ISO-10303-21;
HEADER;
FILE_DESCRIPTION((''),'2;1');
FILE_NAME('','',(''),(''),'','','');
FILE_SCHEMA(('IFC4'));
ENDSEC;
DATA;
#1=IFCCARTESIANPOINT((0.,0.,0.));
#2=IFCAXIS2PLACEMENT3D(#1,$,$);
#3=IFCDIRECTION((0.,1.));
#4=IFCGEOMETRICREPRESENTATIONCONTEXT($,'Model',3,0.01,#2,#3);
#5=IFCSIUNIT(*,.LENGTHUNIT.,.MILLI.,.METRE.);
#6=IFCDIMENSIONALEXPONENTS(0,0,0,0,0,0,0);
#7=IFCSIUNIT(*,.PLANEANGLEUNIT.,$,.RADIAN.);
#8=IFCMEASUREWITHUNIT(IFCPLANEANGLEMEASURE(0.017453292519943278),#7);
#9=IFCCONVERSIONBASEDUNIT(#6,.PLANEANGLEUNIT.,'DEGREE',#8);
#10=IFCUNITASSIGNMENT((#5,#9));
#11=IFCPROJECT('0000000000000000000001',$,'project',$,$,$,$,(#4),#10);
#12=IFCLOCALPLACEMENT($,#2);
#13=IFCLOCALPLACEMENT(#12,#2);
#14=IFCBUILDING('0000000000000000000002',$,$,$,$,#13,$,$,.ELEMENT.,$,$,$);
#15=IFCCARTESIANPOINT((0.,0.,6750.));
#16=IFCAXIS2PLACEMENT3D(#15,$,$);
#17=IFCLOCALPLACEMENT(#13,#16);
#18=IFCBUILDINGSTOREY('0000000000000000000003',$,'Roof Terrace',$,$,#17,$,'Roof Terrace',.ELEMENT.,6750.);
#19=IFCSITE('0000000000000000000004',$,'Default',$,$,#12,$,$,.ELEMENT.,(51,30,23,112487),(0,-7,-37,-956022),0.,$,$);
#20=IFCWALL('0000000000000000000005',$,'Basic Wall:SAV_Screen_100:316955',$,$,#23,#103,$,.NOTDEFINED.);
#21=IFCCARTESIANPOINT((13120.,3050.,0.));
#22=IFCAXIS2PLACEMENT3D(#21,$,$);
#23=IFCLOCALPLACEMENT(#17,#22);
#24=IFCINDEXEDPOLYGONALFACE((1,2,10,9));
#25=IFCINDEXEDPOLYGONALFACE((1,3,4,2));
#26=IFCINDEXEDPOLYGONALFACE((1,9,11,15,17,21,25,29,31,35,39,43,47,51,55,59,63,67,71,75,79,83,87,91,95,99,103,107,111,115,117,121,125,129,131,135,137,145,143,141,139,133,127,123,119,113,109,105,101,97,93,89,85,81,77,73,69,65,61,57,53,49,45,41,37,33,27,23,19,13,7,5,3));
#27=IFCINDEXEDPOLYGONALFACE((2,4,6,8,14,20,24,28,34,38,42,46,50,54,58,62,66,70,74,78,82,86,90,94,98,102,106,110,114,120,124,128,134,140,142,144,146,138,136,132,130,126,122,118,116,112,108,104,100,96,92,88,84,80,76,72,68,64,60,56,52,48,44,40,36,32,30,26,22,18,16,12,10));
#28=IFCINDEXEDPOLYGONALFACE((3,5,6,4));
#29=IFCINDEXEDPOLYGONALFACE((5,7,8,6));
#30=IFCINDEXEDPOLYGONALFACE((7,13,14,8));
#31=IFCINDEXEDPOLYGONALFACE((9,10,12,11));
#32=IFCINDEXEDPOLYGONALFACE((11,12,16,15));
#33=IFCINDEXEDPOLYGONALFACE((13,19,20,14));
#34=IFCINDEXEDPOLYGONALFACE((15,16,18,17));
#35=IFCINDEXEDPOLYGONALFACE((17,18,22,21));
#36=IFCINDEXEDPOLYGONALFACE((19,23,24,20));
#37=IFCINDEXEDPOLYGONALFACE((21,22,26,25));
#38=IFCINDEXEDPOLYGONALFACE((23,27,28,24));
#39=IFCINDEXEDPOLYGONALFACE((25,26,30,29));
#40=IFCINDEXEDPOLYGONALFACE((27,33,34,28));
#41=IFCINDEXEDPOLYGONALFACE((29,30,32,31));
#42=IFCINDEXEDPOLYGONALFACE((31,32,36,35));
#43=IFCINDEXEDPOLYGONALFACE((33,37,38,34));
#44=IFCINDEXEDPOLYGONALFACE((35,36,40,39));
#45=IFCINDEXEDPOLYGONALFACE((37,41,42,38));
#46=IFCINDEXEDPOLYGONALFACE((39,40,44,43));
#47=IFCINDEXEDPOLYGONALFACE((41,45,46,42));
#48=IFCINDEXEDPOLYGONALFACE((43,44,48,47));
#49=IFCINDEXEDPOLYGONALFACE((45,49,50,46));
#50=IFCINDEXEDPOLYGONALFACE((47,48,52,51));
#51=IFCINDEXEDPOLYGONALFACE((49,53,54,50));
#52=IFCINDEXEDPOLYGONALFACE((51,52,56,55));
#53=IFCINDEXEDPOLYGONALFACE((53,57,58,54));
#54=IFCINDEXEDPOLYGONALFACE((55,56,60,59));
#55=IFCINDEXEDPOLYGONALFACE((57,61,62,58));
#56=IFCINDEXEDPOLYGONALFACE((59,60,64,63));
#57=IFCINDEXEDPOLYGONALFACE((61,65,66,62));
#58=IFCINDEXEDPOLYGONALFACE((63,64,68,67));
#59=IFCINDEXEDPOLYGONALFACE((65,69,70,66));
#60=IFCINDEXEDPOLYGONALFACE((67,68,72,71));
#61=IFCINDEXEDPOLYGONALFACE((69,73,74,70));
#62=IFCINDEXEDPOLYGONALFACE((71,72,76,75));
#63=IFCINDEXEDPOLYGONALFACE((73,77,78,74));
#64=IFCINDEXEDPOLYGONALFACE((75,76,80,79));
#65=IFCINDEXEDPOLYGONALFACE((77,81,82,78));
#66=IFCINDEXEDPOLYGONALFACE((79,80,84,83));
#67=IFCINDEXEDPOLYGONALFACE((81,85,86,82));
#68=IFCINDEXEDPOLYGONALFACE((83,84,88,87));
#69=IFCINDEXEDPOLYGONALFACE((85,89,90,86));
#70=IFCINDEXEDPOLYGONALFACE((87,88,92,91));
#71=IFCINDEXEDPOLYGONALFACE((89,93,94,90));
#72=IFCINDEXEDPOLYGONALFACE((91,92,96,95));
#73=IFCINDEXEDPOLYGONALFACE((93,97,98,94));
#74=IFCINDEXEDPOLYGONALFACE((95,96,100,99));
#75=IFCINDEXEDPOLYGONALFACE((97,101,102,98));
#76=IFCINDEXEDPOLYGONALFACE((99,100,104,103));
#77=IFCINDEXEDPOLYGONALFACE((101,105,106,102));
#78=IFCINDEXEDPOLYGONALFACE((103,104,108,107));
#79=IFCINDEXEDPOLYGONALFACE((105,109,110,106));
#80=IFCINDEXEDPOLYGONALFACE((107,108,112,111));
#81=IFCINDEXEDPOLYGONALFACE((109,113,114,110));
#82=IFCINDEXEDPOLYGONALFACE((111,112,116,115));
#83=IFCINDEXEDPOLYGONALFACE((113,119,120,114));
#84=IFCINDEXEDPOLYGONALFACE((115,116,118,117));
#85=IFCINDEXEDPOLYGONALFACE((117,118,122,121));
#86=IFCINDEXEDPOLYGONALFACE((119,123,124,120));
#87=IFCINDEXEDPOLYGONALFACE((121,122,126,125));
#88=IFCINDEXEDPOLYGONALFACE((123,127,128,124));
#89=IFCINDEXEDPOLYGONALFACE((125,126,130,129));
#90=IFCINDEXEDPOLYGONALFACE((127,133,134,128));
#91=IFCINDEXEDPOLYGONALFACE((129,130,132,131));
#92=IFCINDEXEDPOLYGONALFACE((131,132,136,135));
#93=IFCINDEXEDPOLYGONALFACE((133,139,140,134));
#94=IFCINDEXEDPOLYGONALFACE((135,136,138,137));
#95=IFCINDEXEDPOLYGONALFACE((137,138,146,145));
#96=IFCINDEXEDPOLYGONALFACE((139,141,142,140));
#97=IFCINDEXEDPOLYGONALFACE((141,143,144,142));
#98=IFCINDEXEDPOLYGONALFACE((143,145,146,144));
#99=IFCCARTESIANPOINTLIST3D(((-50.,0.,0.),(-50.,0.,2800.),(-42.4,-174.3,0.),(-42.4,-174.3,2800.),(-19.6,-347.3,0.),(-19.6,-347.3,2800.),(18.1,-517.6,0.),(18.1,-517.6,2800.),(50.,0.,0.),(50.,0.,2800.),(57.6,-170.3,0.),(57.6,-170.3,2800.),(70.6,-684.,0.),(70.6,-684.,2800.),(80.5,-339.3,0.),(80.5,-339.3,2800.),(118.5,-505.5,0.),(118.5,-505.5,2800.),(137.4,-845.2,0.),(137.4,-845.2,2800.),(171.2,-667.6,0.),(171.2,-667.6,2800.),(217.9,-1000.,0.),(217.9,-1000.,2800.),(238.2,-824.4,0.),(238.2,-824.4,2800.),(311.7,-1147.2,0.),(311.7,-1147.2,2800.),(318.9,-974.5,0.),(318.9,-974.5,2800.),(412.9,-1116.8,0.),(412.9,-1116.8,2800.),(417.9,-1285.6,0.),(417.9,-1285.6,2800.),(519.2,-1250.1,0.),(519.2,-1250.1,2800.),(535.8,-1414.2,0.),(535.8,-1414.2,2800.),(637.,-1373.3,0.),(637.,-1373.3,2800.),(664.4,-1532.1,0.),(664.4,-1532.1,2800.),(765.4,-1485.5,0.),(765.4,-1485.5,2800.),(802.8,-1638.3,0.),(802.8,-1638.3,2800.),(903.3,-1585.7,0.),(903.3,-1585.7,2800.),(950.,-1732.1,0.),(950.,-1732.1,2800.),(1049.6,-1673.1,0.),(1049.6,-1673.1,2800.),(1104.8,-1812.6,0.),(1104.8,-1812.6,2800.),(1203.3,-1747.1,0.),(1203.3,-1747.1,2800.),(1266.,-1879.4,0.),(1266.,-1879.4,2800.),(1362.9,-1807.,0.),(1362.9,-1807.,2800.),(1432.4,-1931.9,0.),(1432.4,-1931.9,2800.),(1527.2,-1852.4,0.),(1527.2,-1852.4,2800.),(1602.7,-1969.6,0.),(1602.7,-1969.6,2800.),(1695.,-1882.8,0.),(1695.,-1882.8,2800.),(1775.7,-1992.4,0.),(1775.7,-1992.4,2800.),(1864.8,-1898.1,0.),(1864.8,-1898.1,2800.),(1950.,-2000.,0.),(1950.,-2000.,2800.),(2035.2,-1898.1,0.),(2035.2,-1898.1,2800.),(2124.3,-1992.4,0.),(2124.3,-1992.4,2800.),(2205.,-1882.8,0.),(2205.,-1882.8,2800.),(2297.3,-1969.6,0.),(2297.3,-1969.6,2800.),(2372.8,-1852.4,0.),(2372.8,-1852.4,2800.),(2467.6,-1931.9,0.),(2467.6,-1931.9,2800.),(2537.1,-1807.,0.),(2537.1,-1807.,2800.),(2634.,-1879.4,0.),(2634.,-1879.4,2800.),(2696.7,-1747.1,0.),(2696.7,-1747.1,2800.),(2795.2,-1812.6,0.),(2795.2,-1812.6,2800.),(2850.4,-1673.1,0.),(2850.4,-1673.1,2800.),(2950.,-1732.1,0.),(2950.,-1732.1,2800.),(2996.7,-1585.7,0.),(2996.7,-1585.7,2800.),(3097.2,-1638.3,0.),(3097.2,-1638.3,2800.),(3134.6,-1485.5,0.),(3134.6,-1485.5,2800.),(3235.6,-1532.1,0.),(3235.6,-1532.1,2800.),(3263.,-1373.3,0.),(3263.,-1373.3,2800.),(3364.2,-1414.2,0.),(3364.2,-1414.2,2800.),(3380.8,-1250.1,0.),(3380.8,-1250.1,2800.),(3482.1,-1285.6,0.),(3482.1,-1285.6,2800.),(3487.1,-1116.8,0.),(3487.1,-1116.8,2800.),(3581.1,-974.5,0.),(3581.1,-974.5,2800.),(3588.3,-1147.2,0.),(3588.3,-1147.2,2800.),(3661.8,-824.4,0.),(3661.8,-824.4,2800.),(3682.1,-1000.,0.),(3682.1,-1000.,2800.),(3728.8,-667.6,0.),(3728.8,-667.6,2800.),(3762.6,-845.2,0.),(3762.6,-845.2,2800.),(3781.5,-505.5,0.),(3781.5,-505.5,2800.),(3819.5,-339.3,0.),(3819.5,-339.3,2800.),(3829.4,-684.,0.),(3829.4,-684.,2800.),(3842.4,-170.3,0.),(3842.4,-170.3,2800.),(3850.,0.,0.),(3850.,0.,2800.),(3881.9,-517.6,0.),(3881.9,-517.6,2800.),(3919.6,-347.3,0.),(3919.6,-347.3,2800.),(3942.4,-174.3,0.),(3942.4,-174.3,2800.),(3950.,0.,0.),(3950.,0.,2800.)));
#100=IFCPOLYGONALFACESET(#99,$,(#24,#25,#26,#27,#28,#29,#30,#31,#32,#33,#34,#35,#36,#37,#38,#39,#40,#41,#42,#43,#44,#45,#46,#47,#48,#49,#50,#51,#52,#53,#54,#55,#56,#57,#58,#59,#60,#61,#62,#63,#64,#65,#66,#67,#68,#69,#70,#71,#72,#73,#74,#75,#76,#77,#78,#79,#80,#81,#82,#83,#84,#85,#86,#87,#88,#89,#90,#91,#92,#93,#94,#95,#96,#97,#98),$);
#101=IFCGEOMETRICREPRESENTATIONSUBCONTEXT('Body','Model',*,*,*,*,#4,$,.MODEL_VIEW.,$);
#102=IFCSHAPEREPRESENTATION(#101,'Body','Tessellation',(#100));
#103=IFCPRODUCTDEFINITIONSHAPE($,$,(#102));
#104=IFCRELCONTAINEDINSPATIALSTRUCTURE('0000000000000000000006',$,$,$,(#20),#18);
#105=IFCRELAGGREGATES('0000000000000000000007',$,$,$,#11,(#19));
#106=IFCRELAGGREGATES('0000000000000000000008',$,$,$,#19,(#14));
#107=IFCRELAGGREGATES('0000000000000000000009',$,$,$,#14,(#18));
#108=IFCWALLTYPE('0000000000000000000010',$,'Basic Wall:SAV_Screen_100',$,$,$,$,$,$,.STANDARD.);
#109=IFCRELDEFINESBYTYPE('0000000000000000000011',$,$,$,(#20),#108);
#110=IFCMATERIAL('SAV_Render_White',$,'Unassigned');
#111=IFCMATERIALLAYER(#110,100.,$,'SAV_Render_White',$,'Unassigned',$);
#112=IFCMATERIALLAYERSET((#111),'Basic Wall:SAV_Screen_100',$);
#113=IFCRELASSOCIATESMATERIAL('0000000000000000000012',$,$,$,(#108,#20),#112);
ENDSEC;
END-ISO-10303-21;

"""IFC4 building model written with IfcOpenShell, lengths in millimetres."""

from ifc_helpers import new_model, entity, si_unit, converted_unit, direction, frame, frame_2d, origin, place, context, subcontext, project, spatial, polyline, circle_curve, parameter, trimmed, segment, composite_curve, outline, extrude, material, layer, layer_set, layer_usage, type_object, element, save


model = new_model("IFC4")

# Units and contexts
model_context = context("Model", 3, precision=0.01, world=origin(), true_north=direction((0.0, 1.0)))
body_context = subcontext(model_context, "Body", "Model", "MODEL_VIEW")
ifc_project = project(units=[si_unit("LENGTHUNIT", "METRE", prefix="MILLI"), converted_unit("PLANEANGLEUNIT", "DEGREE", entity("IfcPlaneAngleMeasure", 0.017453292519943278), si_unit("PLANEANGLEUNIT", "RADIAN"), dimensions=[0, 0, 0, 0, 0, 0, 0])], contexts=[model_context])

# Site, building, storey
site_placement = place(None, origin())
site = spatial("IfcSite", under=ifc_project, at=site_placement, Name="Default", CompositionType="ELEMENT", RefLatitude=(51, 30, 23, 112487), RefLongitude=(0, -7, -37, -956022), RefElevation=0.0)
building_placement = place(site_placement, origin())
building = spatial("IfcBuilding", under=site, at=building_placement, CompositionType="ELEMENT")
storey_placement = place(building_placement, frame((0.0, 0.0, 6750.0)))
storey = spatial("IfcBuildingStorey", under=building, at=storey_placement, Name="Roof Terrace", LongName="Roof Terrace", CompositionType="ELEMENT", Elevation=6750.0)

# Wall
ifc_material_1 = material(Name="SAV_Render_White", Category="Unassigned")
ifc_layer_1 = layer(ifc_material_1, 100.0, Name="SAV_Render_White", Category="Unassigned")
ifc_layer_set_1 = layer_set([ifc_layer_1], Name="Basic Wall:SAV_Screen_100")
wall_type_1 = type_object("IfcWallType", Name="Basic Wall:SAV_Screen_100", PredefinedType="STANDARD", material=ifc_layer_set_1)
ifc_layer_usage_1 = layer_usage(ifc_layer_set_1, "AXIS2", "NEGATIVE", 50.0)
wall_1_placement = place(storey_placement, frame((13120.0, 3050.0, 0.0)))
element("IfcWall", 1, at=wall_1_placement, inside=storey, type_object=wall_type_1, material=ifc_layer_usage_1, Name="Basic Wall:SAV_Screen_100:316955", PredefinedType="NOTDEFINED", context=body_context, shape_type="SweptSolid", body=[
    extrude(outline(composite_curve([segment(trimmed(circle_curve(frame_2d((1950.0, 0.0), x_axis=(1.0, 0.0)), 1900.0), [parameter(180.0)], [parameter(0.0)], True, "PARAMETER"), False, "CONTINUOUS"), segment(polyline([(50.0, 0.0), (-50.0, 0.0)]), True, "CONTINUOUS"), segment(trimmed(circle_curve(frame_2d((1950.0, 0.0), x_axis=(1.0, 0.0)), 2000.0), [parameter(180.0)], [parameter(0.0)], True, "PARAMETER"), True, "CONTINUOUS"), segment(polyline([(3950.0, 0.0), (3850.0, 0.0)]), True, "CONTINUOUS")], self_intersect=False)), origin(), (0.0, 0.0, 1.0), 2800.0),
])

save(model, "model.ifc")
